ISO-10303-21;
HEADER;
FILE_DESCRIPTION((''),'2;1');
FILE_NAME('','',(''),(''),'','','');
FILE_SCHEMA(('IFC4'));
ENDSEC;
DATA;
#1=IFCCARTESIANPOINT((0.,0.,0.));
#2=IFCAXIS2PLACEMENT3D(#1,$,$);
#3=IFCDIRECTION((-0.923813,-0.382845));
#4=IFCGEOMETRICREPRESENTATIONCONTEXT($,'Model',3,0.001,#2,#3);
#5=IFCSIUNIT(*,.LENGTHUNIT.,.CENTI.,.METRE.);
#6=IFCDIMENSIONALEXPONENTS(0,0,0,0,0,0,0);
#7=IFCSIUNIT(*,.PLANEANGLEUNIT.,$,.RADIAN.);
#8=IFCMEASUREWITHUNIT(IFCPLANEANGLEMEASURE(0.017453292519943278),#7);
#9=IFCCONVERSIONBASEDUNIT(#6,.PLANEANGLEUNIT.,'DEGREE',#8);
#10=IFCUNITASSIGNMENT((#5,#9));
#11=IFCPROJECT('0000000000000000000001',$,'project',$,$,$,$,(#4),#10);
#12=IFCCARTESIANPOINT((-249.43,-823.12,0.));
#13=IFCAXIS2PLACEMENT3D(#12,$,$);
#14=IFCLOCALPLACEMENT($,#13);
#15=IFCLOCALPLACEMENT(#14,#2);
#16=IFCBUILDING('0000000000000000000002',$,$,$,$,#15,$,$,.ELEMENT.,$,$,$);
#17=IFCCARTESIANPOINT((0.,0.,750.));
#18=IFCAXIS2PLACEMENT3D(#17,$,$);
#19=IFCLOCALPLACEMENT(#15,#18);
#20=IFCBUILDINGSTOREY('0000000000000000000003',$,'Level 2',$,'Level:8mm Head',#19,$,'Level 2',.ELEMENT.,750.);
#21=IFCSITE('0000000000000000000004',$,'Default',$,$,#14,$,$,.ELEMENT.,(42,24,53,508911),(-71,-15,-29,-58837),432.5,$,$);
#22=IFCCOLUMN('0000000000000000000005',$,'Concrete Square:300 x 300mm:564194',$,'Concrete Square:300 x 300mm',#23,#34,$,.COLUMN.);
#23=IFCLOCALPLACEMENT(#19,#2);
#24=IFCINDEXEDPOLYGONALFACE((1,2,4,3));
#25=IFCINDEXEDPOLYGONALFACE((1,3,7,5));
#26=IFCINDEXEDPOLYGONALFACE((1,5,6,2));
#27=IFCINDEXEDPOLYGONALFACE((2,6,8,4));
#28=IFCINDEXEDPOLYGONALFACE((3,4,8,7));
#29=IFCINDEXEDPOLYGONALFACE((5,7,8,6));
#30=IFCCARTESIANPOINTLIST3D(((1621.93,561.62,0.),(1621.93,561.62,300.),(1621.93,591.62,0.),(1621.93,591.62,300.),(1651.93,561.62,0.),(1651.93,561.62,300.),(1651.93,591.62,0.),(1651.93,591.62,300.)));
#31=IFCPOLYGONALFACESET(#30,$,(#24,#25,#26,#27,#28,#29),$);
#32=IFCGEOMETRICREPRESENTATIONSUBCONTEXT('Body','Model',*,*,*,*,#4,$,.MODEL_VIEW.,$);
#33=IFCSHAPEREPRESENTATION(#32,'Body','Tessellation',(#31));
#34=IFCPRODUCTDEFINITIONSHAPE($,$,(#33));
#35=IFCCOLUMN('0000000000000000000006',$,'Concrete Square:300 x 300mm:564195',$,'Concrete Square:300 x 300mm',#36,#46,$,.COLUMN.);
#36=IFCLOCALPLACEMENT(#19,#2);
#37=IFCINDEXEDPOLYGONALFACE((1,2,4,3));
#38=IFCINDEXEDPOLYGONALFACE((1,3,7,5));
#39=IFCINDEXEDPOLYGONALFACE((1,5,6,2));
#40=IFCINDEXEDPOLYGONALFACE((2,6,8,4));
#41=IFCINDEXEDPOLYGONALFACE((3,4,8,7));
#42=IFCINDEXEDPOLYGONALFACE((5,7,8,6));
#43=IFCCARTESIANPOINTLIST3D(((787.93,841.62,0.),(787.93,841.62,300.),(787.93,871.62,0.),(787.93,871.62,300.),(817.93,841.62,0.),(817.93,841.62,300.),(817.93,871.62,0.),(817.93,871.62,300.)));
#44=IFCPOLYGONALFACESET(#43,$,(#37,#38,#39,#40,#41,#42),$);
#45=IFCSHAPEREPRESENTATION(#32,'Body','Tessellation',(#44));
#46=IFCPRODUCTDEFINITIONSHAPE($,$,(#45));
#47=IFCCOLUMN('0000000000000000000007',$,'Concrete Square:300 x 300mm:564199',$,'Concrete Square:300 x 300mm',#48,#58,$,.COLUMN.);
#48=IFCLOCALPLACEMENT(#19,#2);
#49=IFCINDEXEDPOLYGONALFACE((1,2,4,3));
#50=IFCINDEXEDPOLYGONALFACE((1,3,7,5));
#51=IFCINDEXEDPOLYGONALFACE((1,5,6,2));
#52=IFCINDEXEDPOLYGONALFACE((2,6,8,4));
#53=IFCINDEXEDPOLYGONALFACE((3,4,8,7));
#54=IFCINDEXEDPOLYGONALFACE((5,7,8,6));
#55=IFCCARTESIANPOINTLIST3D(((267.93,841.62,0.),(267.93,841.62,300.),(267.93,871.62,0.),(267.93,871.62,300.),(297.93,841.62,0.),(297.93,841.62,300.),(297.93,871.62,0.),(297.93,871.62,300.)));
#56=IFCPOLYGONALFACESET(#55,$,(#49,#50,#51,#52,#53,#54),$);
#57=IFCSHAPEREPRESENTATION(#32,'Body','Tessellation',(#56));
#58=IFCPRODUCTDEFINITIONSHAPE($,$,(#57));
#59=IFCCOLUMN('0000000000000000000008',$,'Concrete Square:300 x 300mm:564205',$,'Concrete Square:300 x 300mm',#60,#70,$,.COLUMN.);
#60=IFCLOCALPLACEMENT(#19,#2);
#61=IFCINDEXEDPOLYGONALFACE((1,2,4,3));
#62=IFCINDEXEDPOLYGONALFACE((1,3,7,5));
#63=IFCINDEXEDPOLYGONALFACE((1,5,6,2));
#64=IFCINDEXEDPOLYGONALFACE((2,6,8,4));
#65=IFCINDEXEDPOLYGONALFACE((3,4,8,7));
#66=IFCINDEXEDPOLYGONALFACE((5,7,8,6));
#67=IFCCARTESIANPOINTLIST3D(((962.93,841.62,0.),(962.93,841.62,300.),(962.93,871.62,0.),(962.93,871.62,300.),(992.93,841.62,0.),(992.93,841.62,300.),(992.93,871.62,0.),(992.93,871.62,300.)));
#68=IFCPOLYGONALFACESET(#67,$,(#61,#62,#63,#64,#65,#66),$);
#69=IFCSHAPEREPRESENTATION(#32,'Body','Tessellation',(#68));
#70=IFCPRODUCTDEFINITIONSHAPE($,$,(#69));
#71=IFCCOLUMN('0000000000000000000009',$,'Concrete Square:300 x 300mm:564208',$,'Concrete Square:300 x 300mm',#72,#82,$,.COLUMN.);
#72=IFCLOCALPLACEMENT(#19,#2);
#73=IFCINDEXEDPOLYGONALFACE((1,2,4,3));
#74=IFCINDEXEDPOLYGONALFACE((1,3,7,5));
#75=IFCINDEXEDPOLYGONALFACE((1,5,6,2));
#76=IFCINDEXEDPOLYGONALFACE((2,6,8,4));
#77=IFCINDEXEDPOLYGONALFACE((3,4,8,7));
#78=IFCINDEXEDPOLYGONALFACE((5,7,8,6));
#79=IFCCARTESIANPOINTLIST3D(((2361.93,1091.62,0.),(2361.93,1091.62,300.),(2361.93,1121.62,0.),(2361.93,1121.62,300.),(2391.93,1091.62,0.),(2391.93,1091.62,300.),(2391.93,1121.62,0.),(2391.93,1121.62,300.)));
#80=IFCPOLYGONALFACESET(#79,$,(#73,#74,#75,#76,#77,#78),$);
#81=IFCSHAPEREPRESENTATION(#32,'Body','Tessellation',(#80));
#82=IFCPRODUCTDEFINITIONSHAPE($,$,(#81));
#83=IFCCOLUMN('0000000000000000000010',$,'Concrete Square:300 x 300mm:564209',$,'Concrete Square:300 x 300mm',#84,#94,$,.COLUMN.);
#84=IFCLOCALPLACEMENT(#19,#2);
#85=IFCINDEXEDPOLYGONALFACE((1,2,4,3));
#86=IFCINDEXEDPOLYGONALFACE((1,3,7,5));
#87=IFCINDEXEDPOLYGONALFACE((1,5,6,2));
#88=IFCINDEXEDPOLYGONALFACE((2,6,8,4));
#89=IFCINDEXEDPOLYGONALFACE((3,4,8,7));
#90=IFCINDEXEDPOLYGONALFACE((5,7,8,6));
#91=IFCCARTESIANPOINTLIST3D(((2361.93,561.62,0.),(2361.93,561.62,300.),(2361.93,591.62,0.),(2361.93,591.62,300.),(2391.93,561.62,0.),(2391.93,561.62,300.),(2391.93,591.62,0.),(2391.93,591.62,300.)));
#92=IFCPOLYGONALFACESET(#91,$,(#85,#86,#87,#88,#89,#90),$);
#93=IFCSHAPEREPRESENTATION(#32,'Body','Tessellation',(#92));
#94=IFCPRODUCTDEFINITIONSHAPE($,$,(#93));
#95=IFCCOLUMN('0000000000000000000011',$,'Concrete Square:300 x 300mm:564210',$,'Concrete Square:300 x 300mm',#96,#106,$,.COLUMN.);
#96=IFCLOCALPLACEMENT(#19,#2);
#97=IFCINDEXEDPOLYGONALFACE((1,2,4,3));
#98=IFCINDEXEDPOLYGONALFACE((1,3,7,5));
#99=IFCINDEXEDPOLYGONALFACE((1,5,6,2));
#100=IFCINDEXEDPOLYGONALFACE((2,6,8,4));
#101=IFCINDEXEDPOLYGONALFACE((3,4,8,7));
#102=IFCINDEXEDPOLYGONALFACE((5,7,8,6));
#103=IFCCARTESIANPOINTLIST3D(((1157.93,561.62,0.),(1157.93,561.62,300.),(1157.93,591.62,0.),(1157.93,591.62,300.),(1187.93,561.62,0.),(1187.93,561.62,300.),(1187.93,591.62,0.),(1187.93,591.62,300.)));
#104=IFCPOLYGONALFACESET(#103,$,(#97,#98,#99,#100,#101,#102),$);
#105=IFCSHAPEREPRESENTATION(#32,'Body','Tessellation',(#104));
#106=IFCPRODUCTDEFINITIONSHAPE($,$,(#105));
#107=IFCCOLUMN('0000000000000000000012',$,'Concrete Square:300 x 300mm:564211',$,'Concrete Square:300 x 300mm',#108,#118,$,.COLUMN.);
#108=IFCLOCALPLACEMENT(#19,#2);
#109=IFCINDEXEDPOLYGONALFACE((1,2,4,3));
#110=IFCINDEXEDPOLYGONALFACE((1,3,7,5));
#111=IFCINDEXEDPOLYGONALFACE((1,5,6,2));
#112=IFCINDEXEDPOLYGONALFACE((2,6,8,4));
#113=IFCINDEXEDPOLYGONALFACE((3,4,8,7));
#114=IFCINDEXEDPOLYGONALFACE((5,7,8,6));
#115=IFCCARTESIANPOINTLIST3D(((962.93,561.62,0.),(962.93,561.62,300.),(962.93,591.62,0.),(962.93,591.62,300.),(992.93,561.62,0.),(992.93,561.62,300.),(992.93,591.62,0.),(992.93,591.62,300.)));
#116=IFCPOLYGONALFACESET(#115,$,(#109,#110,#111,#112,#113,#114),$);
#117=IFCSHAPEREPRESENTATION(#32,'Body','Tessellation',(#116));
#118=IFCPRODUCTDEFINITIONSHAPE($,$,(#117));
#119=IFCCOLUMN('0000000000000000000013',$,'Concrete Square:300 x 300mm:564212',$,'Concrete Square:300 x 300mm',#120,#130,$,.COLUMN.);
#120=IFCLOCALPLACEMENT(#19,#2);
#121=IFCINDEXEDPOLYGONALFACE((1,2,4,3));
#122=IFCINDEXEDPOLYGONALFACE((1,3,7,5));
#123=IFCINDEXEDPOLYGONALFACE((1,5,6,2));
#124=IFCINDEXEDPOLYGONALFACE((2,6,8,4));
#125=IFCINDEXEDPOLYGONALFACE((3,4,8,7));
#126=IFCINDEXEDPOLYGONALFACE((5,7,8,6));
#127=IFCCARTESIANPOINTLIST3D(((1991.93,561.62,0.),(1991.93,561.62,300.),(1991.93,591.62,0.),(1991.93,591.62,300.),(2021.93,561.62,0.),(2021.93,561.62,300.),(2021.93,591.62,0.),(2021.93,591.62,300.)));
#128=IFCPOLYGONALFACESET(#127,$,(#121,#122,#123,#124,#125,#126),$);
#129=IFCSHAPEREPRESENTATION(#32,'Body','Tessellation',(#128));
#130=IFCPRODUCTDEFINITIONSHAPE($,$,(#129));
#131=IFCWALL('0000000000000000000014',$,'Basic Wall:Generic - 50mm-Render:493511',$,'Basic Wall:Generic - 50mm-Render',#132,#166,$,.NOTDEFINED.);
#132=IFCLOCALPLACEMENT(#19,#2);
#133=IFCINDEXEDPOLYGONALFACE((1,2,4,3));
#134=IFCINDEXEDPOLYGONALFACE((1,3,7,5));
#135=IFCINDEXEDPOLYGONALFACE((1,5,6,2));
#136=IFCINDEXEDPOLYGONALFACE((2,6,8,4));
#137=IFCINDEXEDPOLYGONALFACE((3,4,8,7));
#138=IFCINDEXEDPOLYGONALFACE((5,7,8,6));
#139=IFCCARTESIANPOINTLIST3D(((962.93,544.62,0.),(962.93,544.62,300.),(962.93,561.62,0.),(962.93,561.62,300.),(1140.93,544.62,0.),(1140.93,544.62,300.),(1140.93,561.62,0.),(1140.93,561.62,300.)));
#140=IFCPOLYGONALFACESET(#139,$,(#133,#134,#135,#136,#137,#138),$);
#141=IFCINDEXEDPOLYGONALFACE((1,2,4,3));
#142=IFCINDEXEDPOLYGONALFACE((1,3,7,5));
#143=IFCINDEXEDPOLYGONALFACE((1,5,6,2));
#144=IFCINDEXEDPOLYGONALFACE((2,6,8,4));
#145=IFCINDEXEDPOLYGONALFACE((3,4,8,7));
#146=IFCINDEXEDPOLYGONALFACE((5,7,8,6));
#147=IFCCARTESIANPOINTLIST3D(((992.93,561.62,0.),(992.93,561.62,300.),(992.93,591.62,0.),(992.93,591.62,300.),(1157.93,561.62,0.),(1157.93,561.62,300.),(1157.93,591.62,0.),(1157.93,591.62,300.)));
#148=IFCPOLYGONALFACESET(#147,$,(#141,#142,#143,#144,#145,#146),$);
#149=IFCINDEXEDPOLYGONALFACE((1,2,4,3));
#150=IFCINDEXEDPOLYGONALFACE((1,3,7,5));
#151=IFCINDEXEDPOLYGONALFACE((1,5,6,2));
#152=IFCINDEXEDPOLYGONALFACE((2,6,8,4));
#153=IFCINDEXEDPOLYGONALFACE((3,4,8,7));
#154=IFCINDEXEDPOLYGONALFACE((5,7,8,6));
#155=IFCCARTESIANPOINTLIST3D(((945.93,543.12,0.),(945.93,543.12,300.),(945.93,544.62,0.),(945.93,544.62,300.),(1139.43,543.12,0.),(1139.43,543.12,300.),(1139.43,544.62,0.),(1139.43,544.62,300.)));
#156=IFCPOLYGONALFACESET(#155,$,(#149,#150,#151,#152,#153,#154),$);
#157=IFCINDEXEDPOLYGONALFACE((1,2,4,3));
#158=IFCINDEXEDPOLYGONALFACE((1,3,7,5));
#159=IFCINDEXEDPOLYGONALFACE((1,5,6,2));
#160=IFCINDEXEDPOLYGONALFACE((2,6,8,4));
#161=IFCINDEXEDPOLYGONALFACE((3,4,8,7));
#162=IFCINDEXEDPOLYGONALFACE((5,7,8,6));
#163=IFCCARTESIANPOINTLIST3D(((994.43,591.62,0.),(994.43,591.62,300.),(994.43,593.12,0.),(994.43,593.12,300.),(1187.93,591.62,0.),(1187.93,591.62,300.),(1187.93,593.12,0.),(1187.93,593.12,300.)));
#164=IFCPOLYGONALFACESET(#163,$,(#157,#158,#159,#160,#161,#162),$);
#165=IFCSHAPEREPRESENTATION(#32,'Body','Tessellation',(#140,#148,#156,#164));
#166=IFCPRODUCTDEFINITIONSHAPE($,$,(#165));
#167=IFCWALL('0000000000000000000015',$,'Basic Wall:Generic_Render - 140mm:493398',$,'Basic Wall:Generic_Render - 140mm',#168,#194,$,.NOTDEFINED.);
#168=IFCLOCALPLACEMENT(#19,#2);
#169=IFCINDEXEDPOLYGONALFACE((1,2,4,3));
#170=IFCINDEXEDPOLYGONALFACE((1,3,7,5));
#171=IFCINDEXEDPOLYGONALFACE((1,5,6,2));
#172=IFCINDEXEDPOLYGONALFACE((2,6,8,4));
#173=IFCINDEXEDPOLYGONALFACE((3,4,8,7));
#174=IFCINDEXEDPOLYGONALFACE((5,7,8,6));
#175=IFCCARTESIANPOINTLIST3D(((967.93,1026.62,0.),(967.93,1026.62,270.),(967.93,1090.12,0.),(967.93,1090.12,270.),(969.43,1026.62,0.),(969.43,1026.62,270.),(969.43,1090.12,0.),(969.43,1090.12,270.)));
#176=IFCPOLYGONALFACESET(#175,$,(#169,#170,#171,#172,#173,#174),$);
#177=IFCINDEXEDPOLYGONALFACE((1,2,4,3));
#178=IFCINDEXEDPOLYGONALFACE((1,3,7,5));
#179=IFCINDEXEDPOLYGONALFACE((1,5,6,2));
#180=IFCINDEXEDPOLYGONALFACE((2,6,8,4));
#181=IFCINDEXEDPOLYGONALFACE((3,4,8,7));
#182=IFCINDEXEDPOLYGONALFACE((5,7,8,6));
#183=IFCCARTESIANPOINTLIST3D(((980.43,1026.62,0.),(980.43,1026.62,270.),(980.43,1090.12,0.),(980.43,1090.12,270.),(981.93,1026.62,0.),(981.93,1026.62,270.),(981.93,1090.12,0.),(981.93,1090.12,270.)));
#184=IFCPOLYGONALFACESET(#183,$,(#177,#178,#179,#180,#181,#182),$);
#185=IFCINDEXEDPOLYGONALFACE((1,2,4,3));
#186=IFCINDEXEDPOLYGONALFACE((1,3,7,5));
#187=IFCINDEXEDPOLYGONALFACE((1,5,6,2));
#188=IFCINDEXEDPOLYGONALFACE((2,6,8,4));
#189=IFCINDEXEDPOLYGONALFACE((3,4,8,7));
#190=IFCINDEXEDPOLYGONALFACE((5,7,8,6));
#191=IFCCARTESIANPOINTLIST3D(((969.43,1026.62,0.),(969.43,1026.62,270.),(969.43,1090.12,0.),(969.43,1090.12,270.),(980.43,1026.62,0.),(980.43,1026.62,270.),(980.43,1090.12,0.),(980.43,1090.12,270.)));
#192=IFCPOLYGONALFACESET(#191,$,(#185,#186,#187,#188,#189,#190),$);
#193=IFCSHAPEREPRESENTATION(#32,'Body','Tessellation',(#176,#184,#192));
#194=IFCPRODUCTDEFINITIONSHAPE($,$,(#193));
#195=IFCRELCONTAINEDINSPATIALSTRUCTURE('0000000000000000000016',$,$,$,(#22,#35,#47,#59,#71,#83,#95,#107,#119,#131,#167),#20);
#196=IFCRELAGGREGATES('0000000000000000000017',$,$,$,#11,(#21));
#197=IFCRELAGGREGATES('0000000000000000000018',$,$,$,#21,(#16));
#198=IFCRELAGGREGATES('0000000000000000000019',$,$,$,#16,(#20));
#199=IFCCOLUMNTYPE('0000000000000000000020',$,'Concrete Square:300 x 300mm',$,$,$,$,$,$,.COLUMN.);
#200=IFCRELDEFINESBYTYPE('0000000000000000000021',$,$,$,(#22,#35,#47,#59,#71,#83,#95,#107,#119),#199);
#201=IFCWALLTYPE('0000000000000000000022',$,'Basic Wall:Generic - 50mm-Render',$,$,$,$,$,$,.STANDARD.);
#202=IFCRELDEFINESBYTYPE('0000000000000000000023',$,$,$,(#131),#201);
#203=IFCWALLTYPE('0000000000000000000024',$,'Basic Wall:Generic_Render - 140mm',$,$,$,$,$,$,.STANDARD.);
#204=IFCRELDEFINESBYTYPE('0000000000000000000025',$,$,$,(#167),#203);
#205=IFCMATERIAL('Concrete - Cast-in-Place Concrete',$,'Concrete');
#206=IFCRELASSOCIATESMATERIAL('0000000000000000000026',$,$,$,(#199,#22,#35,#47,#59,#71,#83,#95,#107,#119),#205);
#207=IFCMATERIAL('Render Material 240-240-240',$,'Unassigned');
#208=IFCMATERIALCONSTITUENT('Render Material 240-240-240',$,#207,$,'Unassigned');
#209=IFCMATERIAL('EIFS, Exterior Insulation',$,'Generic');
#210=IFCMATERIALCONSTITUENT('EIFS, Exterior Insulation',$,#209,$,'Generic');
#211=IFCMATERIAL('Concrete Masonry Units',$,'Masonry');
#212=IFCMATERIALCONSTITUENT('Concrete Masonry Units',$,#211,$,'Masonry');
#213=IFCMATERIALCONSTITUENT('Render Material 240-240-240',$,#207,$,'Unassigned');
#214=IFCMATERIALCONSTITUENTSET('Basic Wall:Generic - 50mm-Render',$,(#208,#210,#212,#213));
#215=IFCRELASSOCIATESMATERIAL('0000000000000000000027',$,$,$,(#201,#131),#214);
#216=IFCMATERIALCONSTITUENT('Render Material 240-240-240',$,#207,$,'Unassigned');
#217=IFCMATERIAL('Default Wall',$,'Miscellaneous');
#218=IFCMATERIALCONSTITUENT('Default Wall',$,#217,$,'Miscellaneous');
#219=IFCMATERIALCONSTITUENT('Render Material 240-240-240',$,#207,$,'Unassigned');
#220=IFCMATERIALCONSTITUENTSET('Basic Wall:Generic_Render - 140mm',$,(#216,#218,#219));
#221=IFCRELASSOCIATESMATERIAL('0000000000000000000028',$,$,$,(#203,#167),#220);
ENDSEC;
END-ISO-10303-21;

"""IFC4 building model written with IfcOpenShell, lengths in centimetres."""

from ifc_helpers import new_model, entity, si_unit, converted_unit, direction, frame, origin, place, context, subcontext, project, spatial, indexed_curve, outline, extrude, source, transform, mapped, material, constituent, constituent_set, type_object, type_shapes, element, save


model = new_model("IFC4")

# Units and contexts
model_context = context("Model", 3, precision=0.001, world=origin(), true_north=direction((-0.923813, -0.382845)))
body_context = subcontext(model_context, "Body", "Model", "MODEL_VIEW")
ifc_project = project(units=[si_unit("LENGTHUNIT", "METRE", prefix="CENTI"), converted_unit("PLANEANGLEUNIT", "DEGREE", entity("IfcPlaneAngleMeasure", 0.017453292519943278), si_unit("PLANEANGLEUNIT", "RADIAN"), dimensions=[0, 0, 0, 0, 0, 0, 0])], contexts=[model_context])

# Site, building, storey
site_placement = place(None, frame((-249.43, -823.12, 0.0)))
site = spatial("IfcSite", under=ifc_project, at=site_placement, Name="Default", CompositionType="ELEMENT", RefLatitude=(42, 24, 53, 508911), RefLongitude=(-71, -15, -29, -58837), RefElevation=432.5)
building_placement = place(site_placement, origin())
building = spatial("IfcBuilding", under=site, at=building_placement, CompositionType="ELEMENT")
storey_placement = place(building_placement, frame((0.0, 0.0, 750.0)))
storey = spatial("IfcBuildingStorey", under=building, at=storey_placement, Name="Level 2", ObjectType="Level:8mm Head", LongName="Level 2", CompositionType="ELEMENT", Elevation=750.0)

# Columns
ifc_material_1 = material(Name="Concrete - Cast-in-Place Concrete", Category="Concrete")
column_type = type_object("IfcColumnType", Name="Concrete Square:300 x 300mm", PredefinedType="COLUMN", material=ifc_material_1)
shared_shape = source(origin(), body_context, "Body", "SweptSolid", [
    extrude(outline(indexed_curve([(-15.0, -15.0), (15.0, -15.0), (15.0, 15.0), (-15.0, 15.0), (-15.0, -15.0)], self_intersect=False)), frame((0.0, 0.0, 750.0), z_axis=(0.0, 0.0, 1.0), x_axis=(-1.0, 0.0, 0.0)), (0.0, 0.0, 1.0), 300.0),
])
type_shapes(column_type, [shared_shape])
for number, where, name in (
    (1, (1636.93, 576.62, -750.0), "Concrete Square:300 x 300mm:564194"),
    (2, (802.93, 856.62, -750.0), "Concrete Square:300 x 300mm:564195"),
    (3, (282.93, 856.62, -750.0), "Concrete Square:300 x 300mm:564199"),
    (4, (977.93, 856.62, -750.0), "Concrete Square:300 x 300mm:564205"),
    (5, (2376.93, 1106.62, -750.0), "Concrete Square:300 x 300mm:564208"),
    (6, (2376.93, 576.62, -750.0), "Concrete Square:300 x 300mm:564209"),
    (7, (1172.93, 576.62, -750.0), "Concrete Square:300 x 300mm:564210"),
    (8, (977.93, 576.62, -750.0), "Concrete Square:300 x 300mm:564211"),
    (9, (2006.93, 576.62, -750.0), "Concrete Square:300 x 300mm:564212"),
):
    element("IfcColumn", number, at=place(storey_placement, frame(where)), inside=storey, type_object=column_type, material=ifc_material_1, Name=name, ObjectType="Concrete Square:300 x 300mm", PredefinedType="COLUMN", context=body_context, shape_type="MappedRepresentation", body=[
        mapped(shared_shape, transform((0.0, 0.0, 0.0), scale=1.0)),
    ])

# Walls
ifc_material_2 = material(Name="Render Material 240-240-240", Category="Unassigned")
ifc_material_3 = material(Name="Default Wall", Category="Miscellaneous")
ifc_constituent_1 = constituent(ifc_material_2, Name="Render Material 240-240-240", Category="Unassigned")
ifc_material_4 = material(Name="EIFS, Exterior Insulation", Category="Generic")
ifc_constituent_2 = constituent(ifc_material_4, Name="EIFS, Exterior Insulation", Category="Generic")
ifc_material_5 = material(Name="Concrete Masonry Units", Category="Masonry")
ifc_constituent_3 = constituent(ifc_material_5, Name="Concrete Masonry Units", Category="Masonry")
ifc_constituent_4 = constituent(ifc_material_2, Name="Render Material 240-240-240", Category="Unassigned")
ifc_constituent_set_1 = constituent_set(constituents=[ifc_constituent_1, ifc_constituent_2, ifc_constituent_3, ifc_constituent_4], Name="Basic Wall:Generic - 50mm-Render")
wall_type_1 = type_object("IfcWallType", Name="Basic Wall:Generic - 50mm-Render", PredefinedType="STANDARD", material=ifc_constituent_set_1)
wall_1_placement = place(storey_placement, frame((1139.43, 568.12, 0.0), z_axis=(0.0, 0.0, 1.0), x_axis=(-1.0, 0.0, 0.0)))
element("IfcWall", 10, at=wall_1_placement, inside=storey, type_object=wall_type_1, material=ifc_constituent_set_1, Name="Basic Wall:Generic - 50mm-Render:493511", ObjectType="Basic Wall:Generic - 50mm-Render", PredefinedType="NOTDEFINED", context=body_context, shape_type="SweptSolid", body=[
    extrude(outline(indexed_curve([(-89.0, -8.5), (89.0, -8.5), (89.0, 8.5), (-89.0, 8.5), (-89.0, -8.5)], self_intersect=False)), frame((87.5, 15.0, 0.0)), (0.0, 0.0, 1.0), 300.0),
    extrude(outline(indexed_curve([(-82.5, -15.0), (82.5, -15.0), (82.5, 15.0), (-82.5, 15.0), (-82.5, -15.0)], self_intersect=False)), frame((64.0, -8.5, 0.0)), (0.0, 0.0, 1.0), 300.0),
    extrude(outline(indexed_curve([(-0.75, -96.75), (0.75, -96.75), (0.75, 96.75), (-0.75, 96.75), (-0.75, -96.75)], self_intersect=False)), frame((96.75, 24.25, 0.0), z_axis=(0.0, 0.0, 1.0), x_axis=(0.0, -1.0, 0.0)), (0.0, 0.0, 1.0), 300.0),
    extrude(outline(indexed_curve([(-0.75, -96.75), (0.75, -96.75), (0.75, 96.75), (-0.75, 96.75), (-0.75, -96.75)], self_intersect=False)), frame((48.25, -24.25, 0.0), z_axis=(0.0, 0.0, 1.0), x_axis=(0.0, 1.0, 0.0)), (0.0, 0.0, 1.0), 300.0),
])
ifc_constituent_5 = constituent(ifc_material_2, Name="Render Material 240-240-240", Category="Unassigned")
ifc_constituent_6 = constituent(ifc_material_3, Name="Default Wall", Category="Miscellaneous")
ifc_constituent_7 = constituent(ifc_material_2, Name="Render Material 240-240-240", Category="Unassigned")
ifc_constituent_set_2 = constituent_set(constituents=[ifc_constituent_5, ifc_constituent_6, ifc_constituent_7], Name="Basic Wall:Generic_Render - 140mm")
wall_type_2 = type_object("IfcWallType", Name="Basic Wall:Generic_Render - 140mm", PredefinedType="STANDARD", material=ifc_constituent_set_2)
wall_2_placement = place(storey_placement, frame((974.93, 1090.12, 0.0), z_axis=(0.0, 0.0, 1.0), x_axis=(0.0, -1.0, 0.0)))
element("IfcWall", 11, at=wall_2_placement, inside=storey, type_object=wall_type_2, material=ifc_constituent_set_2, Name="Basic Wall:Generic_Render - 140mm:493398", ObjectType="Basic Wall:Generic_Render - 140mm", PredefinedType="NOTDEFINED", context=body_context, shape_type="SweptSolid", body=[
    extrude(outline(indexed_curve([(-0.75, -31.75), (0.75, -31.75), (0.75, 31.75), (-0.75, 31.75), (-0.75, -31.75)], self_intersect=False)), frame((31.75, -6.25, 0.0), z_axis=(0.0, 0.0, 1.0), x_axis=(0.0, 1.0, 0.0)), (0.0, 0.0, 1.0), 270.0),
    extrude(outline(indexed_curve([(-0.75, -31.75), (0.75, -31.75), (0.75, 31.75), (-0.75, 31.75), (-0.75, -31.75)], self_intersect=False)), frame((31.75, 6.25, 0.0), z_axis=(0.0, 0.0, 1.0), x_axis=(0.0, -1.0, 0.0)), (0.0, 0.0, 1.0), 270.0),
    extrude(outline(indexed_curve([(-31.75, -5.5), (31.75, -5.5), (31.75, 5.5), (-31.75, 5.5), (-31.75, -5.5)], self_intersect=False)), frame((31.75, 0.0, 0.0)), (0.0, 0.0, 1.0), 270.0),
])

save(model, "model.ifc")
